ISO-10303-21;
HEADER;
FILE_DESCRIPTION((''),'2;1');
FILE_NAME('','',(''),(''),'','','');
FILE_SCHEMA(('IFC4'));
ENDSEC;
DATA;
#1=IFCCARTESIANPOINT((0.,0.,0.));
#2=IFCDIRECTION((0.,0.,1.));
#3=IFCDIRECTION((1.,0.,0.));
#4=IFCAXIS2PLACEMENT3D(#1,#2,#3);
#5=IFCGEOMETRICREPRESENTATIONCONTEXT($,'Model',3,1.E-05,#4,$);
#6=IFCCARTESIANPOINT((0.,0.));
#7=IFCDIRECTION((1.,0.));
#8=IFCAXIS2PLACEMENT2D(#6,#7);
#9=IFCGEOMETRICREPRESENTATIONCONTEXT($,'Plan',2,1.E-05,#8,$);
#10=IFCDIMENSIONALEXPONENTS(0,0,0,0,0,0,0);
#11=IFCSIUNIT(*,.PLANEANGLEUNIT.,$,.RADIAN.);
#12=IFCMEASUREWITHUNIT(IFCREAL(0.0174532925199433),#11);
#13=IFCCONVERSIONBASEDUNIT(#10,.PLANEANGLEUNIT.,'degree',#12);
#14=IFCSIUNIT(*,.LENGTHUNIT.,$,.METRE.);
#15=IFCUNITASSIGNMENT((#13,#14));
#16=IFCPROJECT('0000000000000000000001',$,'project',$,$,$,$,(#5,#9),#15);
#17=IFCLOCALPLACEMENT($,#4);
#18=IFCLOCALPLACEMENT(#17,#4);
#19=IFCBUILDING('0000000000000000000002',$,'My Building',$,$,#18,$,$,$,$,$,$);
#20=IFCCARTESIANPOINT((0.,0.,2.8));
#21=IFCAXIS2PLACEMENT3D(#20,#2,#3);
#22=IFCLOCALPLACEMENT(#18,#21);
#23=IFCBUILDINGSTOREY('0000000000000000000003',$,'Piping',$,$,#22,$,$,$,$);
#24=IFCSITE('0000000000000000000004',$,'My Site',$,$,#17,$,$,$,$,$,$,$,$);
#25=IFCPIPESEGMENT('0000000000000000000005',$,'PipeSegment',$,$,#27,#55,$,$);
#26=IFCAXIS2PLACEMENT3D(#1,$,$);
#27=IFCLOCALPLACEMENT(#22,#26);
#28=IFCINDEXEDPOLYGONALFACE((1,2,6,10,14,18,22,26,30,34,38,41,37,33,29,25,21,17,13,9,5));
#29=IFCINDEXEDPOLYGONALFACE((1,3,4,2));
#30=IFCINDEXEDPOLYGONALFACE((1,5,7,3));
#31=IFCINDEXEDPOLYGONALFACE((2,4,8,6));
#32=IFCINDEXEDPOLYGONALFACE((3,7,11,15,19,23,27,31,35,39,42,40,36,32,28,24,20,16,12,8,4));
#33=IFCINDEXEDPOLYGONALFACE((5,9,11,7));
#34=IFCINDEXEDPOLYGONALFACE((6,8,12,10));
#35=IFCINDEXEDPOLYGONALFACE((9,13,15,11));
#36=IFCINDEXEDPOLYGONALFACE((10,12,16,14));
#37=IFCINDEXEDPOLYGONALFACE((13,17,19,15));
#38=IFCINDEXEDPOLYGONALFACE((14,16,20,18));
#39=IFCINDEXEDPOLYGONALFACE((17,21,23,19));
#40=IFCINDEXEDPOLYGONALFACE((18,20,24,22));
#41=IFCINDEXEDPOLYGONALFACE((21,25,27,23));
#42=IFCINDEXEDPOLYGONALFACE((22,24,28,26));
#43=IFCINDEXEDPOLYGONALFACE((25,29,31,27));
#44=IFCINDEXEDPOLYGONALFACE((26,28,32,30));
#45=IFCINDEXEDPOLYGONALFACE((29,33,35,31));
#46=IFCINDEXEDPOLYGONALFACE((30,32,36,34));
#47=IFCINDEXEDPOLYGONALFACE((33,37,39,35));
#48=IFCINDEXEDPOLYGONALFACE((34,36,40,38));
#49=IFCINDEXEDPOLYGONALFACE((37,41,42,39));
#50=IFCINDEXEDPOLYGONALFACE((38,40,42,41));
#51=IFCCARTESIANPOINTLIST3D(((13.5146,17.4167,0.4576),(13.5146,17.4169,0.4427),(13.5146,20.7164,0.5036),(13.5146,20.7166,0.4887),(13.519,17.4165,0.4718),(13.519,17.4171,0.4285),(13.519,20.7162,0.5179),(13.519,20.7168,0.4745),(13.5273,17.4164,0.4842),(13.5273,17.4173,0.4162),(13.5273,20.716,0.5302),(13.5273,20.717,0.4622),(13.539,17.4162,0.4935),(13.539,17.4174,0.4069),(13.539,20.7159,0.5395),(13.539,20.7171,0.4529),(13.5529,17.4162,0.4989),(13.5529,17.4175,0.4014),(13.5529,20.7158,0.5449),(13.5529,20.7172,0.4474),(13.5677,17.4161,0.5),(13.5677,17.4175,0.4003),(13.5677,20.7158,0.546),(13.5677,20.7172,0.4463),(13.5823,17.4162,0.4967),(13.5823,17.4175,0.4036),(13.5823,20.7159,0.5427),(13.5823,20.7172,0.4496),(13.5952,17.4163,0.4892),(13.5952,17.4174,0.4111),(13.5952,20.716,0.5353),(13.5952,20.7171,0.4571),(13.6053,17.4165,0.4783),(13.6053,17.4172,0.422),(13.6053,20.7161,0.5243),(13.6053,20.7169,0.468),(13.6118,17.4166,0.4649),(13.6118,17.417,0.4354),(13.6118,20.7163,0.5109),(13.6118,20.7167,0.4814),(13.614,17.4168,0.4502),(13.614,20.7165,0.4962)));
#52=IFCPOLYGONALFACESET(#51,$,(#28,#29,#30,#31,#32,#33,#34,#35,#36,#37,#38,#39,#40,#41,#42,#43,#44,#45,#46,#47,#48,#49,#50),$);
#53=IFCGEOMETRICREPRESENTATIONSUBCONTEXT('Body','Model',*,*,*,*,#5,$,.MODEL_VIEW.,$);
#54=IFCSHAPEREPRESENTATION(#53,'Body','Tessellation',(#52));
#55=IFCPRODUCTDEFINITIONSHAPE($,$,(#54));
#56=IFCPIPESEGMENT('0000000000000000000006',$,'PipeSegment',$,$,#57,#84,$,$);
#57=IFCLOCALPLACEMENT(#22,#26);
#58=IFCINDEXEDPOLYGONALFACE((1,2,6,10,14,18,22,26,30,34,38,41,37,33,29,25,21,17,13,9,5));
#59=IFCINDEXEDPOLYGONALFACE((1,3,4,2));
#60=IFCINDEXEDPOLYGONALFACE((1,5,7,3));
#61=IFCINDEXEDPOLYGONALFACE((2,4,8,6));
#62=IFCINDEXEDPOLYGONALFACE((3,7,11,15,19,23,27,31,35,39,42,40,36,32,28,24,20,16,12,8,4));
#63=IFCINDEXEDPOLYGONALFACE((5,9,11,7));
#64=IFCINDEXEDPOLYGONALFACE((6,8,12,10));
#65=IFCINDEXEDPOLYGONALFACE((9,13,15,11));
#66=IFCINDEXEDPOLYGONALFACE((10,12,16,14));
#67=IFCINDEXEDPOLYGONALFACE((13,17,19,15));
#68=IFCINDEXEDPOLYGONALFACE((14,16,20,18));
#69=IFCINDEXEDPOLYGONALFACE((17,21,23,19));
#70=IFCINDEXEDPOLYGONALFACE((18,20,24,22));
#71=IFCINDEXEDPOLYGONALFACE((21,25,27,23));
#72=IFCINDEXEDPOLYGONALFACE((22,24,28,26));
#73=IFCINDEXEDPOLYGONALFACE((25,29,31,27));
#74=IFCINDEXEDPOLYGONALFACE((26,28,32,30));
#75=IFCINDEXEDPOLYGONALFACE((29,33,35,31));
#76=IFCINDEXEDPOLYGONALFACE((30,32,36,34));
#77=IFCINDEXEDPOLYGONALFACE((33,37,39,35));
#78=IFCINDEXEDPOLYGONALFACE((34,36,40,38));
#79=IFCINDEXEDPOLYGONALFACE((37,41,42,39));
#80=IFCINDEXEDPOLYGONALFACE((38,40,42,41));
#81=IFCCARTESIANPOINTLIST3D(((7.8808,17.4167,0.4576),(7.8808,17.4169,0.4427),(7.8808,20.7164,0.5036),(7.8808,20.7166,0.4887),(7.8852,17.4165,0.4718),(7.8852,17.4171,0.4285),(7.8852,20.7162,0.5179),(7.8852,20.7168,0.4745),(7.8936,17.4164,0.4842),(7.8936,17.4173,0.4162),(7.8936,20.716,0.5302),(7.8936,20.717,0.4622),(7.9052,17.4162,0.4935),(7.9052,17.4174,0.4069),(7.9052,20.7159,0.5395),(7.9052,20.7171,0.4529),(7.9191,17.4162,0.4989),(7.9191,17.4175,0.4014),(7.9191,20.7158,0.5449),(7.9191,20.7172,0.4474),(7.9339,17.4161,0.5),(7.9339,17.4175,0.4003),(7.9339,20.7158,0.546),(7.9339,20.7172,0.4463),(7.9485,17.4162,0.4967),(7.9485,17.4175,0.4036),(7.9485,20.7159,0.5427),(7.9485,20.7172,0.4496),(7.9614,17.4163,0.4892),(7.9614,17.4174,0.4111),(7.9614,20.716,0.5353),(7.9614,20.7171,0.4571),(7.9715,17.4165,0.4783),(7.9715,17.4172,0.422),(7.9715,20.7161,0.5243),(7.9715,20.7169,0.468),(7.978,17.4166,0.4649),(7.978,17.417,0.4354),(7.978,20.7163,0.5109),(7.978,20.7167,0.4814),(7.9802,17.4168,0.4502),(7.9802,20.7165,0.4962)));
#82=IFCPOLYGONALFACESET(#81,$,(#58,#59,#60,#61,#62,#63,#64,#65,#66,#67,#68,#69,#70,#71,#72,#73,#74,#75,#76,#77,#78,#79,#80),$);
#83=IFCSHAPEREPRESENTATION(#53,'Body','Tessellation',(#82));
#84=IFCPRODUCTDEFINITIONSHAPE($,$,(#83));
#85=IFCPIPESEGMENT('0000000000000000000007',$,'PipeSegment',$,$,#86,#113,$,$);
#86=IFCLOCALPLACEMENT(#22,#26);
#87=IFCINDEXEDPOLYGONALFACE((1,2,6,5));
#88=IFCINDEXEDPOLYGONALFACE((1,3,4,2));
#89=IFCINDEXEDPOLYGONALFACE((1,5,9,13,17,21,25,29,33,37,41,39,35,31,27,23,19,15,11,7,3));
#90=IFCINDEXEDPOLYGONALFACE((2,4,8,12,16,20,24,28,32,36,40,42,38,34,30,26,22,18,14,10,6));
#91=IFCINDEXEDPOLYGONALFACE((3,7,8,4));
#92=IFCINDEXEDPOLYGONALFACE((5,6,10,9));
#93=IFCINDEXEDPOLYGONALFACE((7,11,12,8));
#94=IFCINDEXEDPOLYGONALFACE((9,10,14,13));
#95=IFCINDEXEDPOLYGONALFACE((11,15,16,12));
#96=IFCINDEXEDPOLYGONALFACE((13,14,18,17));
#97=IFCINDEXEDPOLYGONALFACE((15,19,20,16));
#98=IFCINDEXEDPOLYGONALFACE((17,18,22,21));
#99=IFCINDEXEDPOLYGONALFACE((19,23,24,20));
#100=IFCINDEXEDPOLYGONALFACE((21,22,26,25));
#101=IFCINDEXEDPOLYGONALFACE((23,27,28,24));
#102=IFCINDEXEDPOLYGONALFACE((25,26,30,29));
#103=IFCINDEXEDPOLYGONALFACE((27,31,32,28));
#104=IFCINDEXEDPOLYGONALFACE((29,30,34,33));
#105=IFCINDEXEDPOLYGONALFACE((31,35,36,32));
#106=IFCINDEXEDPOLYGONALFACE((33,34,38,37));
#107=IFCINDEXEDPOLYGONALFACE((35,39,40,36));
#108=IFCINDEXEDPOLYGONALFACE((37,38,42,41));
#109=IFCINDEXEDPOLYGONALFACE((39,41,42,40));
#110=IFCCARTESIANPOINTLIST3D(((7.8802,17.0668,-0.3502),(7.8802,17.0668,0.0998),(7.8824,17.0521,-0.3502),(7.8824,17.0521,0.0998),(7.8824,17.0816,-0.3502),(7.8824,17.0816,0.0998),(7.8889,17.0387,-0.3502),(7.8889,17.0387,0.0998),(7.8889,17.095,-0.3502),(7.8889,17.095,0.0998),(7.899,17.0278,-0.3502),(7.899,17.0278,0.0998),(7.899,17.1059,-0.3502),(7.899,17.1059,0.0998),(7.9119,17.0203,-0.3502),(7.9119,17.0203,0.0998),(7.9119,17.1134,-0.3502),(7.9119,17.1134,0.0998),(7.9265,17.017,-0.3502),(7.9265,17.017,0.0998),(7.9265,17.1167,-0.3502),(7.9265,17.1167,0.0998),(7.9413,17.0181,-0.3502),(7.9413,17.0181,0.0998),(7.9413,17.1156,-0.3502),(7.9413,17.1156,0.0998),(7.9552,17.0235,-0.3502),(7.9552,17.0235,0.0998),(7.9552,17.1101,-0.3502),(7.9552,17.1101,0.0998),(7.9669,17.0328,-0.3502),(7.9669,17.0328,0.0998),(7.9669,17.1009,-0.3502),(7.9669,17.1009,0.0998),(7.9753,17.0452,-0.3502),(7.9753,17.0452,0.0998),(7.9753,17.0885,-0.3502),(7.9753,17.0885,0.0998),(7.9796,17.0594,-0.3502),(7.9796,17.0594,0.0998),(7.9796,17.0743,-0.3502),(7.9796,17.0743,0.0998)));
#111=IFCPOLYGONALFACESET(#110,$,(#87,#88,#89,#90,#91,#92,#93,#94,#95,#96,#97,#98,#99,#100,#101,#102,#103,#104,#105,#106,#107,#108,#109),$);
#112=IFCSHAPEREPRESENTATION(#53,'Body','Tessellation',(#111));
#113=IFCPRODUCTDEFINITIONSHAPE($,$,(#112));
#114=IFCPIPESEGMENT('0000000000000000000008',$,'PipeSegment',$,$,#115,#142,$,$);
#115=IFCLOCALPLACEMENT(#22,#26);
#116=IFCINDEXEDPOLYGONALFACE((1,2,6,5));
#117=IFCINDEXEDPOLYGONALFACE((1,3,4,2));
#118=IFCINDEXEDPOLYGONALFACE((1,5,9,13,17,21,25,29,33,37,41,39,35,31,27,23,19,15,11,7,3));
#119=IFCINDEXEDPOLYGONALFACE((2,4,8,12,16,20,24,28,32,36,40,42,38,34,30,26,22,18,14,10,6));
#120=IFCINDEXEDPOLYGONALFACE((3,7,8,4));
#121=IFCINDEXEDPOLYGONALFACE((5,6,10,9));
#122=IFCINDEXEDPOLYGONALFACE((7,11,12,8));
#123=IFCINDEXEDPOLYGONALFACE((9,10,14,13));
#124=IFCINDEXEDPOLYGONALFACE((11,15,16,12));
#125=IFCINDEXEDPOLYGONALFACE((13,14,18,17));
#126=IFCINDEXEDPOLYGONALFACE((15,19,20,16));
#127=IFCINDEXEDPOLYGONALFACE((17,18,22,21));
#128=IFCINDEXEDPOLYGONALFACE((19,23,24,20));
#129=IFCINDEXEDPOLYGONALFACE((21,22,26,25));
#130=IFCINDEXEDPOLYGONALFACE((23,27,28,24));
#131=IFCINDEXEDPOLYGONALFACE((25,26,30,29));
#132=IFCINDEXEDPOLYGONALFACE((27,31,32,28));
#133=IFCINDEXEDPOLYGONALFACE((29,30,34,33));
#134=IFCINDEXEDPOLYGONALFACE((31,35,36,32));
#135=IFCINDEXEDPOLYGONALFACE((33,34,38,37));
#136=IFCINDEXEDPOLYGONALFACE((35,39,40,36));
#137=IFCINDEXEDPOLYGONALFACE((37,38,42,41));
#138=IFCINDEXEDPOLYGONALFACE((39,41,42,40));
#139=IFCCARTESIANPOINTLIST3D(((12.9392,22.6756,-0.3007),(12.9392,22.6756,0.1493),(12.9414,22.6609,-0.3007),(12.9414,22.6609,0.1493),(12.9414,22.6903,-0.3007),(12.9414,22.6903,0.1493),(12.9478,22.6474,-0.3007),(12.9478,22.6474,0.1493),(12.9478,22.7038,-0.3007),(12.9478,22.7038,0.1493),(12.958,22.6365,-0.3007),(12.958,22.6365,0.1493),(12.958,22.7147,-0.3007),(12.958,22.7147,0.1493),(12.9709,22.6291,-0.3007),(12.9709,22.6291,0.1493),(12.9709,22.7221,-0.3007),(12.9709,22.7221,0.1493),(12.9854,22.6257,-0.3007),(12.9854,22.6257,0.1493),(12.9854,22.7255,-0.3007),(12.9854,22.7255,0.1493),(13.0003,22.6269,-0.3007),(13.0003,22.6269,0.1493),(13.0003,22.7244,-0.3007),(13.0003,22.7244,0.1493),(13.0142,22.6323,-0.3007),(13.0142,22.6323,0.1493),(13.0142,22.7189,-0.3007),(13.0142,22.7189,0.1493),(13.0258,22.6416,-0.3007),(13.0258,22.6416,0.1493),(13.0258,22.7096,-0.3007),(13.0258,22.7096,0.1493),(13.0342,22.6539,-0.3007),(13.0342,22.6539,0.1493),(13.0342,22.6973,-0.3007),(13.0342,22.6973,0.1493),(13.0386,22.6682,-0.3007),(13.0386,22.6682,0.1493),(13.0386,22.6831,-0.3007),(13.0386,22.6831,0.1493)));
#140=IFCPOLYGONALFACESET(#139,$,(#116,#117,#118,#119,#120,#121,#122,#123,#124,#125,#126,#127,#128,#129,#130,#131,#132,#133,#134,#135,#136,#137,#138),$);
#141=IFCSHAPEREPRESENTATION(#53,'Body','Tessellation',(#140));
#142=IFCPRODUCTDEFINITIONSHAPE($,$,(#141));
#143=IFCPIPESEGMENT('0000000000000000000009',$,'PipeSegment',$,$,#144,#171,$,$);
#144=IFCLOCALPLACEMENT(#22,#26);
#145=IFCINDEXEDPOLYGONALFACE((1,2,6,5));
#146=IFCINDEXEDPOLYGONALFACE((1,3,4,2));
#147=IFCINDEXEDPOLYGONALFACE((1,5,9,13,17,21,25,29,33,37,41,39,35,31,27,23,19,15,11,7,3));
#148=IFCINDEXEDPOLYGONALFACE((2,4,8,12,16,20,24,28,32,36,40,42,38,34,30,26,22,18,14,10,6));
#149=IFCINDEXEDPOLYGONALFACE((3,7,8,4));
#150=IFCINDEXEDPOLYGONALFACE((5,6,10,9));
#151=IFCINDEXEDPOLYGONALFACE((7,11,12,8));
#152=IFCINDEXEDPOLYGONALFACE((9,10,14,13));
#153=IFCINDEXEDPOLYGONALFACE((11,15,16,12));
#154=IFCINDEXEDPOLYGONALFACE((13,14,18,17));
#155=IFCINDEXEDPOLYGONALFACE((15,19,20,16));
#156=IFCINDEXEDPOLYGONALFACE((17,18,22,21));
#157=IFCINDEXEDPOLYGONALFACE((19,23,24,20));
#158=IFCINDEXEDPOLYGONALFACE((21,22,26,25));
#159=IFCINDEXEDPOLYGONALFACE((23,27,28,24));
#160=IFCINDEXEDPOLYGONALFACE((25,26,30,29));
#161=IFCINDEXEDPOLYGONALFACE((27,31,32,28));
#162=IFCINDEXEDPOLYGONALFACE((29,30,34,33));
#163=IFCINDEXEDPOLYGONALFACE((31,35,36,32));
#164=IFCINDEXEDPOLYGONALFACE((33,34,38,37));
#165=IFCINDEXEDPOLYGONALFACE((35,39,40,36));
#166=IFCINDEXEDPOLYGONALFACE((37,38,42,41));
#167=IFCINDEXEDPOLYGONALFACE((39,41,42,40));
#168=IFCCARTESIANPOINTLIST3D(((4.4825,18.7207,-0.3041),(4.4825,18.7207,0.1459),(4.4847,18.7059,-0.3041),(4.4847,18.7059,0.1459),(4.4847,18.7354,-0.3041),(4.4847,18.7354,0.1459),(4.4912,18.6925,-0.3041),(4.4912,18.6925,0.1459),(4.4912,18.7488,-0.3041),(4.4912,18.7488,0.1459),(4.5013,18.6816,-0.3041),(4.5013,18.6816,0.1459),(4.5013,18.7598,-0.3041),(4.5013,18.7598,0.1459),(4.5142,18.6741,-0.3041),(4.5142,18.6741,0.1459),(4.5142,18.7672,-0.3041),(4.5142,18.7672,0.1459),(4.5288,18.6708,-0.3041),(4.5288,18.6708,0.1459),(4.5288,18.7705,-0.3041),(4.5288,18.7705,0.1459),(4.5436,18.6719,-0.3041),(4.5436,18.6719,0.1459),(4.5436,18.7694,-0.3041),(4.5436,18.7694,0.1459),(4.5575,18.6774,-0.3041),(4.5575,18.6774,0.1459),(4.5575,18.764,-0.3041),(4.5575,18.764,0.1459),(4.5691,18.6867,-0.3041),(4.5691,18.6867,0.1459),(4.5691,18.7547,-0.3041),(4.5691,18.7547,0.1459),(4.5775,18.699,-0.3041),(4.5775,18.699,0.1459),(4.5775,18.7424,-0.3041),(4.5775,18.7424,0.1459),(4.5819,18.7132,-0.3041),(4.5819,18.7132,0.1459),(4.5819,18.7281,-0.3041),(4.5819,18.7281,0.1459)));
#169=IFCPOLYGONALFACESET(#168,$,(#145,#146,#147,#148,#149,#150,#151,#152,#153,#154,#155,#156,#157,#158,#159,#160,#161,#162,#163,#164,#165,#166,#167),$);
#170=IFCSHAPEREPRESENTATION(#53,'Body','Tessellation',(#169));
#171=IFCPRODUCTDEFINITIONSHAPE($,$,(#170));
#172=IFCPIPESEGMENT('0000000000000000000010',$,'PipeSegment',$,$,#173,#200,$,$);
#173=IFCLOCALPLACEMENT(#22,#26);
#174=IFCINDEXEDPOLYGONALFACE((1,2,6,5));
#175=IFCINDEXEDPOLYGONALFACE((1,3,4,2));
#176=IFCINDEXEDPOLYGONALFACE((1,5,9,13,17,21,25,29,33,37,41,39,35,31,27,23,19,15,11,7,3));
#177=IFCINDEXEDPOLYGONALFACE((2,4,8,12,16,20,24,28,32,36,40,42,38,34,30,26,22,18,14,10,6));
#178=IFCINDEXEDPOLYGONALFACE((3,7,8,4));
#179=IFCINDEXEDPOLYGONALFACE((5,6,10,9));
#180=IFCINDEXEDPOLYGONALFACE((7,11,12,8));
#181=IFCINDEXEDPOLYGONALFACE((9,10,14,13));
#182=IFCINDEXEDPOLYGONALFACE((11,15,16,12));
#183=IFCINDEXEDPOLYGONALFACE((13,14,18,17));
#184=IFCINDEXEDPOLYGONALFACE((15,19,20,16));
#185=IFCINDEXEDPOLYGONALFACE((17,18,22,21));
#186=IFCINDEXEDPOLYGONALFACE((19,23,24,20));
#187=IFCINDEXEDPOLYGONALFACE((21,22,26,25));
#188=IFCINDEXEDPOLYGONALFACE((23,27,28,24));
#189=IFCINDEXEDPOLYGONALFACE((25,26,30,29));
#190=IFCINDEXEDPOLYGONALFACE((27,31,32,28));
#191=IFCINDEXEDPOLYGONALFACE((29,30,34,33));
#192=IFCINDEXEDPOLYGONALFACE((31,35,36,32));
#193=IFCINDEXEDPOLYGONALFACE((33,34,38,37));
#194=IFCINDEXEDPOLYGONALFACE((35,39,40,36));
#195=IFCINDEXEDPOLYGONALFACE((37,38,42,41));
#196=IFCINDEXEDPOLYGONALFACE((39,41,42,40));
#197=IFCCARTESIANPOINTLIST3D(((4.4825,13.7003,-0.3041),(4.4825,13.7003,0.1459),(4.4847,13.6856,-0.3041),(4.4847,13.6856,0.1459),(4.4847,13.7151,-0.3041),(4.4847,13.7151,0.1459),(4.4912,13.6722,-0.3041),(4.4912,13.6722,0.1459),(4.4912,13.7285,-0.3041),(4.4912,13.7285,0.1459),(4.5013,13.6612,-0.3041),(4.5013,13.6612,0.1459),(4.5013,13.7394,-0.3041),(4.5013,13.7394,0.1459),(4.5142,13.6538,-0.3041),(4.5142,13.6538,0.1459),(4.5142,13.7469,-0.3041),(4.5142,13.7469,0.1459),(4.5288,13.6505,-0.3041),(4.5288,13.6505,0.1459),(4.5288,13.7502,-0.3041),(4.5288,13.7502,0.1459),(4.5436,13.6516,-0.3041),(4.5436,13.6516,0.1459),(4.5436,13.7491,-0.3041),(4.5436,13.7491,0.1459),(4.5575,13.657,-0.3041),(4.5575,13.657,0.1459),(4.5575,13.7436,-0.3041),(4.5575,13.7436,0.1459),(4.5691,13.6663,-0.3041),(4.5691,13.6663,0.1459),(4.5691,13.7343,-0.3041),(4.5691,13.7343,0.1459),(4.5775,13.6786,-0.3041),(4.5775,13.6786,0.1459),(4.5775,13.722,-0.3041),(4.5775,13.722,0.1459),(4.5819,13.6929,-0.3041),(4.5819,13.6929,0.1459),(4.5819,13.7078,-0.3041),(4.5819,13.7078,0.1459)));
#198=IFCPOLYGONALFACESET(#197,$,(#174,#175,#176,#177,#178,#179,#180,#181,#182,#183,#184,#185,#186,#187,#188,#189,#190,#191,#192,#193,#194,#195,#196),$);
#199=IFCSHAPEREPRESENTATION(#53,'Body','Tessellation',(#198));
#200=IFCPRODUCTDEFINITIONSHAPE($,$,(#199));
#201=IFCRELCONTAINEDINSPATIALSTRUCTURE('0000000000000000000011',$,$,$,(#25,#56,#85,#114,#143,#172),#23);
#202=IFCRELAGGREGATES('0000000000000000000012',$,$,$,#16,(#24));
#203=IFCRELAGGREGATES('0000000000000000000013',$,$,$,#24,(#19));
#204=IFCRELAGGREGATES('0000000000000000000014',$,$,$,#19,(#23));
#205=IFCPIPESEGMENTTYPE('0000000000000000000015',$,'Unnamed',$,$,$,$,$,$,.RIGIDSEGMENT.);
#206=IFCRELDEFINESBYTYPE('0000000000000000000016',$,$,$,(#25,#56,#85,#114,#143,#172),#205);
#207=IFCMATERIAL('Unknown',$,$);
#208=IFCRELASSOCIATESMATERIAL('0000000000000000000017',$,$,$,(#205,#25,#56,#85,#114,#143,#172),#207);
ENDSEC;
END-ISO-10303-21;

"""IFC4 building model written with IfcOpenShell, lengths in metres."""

from ifc_helpers import new_model, entity, si_unit, converted_unit, frame, origin_with_axes, origin_2d_with_axis, place, context, subcontext, project, spatial, circle, extrude, material, material_profile, profile_set, profile_usage, type_object, element, save


model = new_model("IFC4")

# Units and contexts
model_context = context("Model", 3, precision=1e-05, world=origin_with_axes())
plan_context = context("Plan", 2, precision=1e-05, world=origin_2d_with_axis())
body_context = subcontext(model_context, "Body", "Model", "MODEL_VIEW")
ifc_project = project(units=[converted_unit("PLANEANGLEUNIT", "degree", entity("IfcReal", 0.0174532925199433), si_unit("PLANEANGLEUNIT", "RADIAN"), dimensions=[0, 0, 0, 0, 0, 0, 0]), si_unit("LENGTHUNIT", "METRE")], contexts=[model_context, plan_context])

# Site, building, storey
site_placement = place(None, origin_with_axes())
site = spatial("IfcSite", under=ifc_project, at=site_placement, Name="My Site")
building_placement = place(site_placement, origin_with_axes())
building = spatial("IfcBuilding", under=site, at=building_placement, Name="My Building")
storey_placement = place(building_placement, frame((0.0, 0.0, 2.8), z_axis=(0.0, 0.0, 1.0), x_axis=(1.0, 0.0, 0.0)))
storey = spatial("IfcBuildingStorey", under=building, at=storey_placement, Name="Piping")

# Pipe segments
ifc_material = material(Name="Unknown")
ifc_material_profile_1 = material_profile(ifc_material, circle(Radius=0.05))
ifc_profile_set_1 = profile_set([ifc_material_profile_1])
pipe_segment_type = type_object("IfcPipeSegmentType", Name="Unnamed", PredefinedType="RIGIDSEGMENT", material=ifc_profile_set_1)
ifc_profile_usage_1 = profile_usage(ifc_profile_set_1, cardinal=5)
pipe_segment_1_placement = place(storey_placement, frame((13.564, 20.7165, 0.4962), z_axis=(0.0, -0.999903, -0.013947), x_axis=(1.0, 0.0, 0.0)))
element("IfcPipeSegment", 1, at=pipe_segment_1_placement, inside=storey, type_object=pipe_segment_type, material=ifc_profile_usage_1, Name="PipeSegment", context=body_context, shape_type="SweptSolid", body=[
    extrude(circle(Radius=0.05), origin_with_axes(), (0.0, 0.0, 1.0), 3.3),
])
ifc_profile_usage_2 = profile_usage(ifc_profile_set_1, cardinal=5)
pipe_segment_2_placement = place(storey_placement, frame((7.9302, 20.7165, 0.4962), z_axis=(0.0, -0.999903, -0.013947), x_axis=(1.0, 0.0, 0.0)))
element("IfcPipeSegment", 2, at=pipe_segment_2_placement, inside=storey, type_object=pipe_segment_type, material=ifc_profile_usage_2, Name="PipeSegment", context=body_context, shape_type="SweptSolid", body=[
    extrude(circle(Radius=0.05), origin_with_axes(), (0.0, 0.0, 1.0), 3.3),
])
ifc_profile_usage_3 = profile_usage(ifc_profile_set_1, cardinal=5)
pipe_segment_3_placement = place(storey_placement, frame((7.9302, 17.0668, 0.0998), z_axis=(0.0, 0.0, -1.0), x_axis=(-1.0, 0.0, 0.0)))
element("IfcPipeSegment", 3, at=pipe_segment_3_placement, inside=storey, type_object=pipe_segment_type, material=ifc_profile_usage_3, Name="PipeSegment", context=body_context, shape_type="SweptSolid", body=[
    extrude(circle(Radius=0.05), origin_with_axes(), (0.0, 0.0, 1.0), 0.45),
])
ifc_profile_usage_4 = profile_usage(ifc_profile_set_1, cardinal=5)
pipe_segment_4_placement = place(storey_placement, frame((12.9892, 22.6756, 0.1493), z_axis=(0.0, 0.0, -1.0), x_axis=(-1.0, 0.0, 0.0)))
element("IfcPipeSegment", 4, at=pipe_segment_4_placement, inside=storey, type_object=pipe_segment_type, material=ifc_profile_usage_4, Name="PipeSegment", context=body_context, shape_type="SweptSolid", body=[
    extrude(circle(Radius=0.05), origin_with_axes(), (0.0, 0.0, 1.0), 0.45),
])
ifc_profile_usage_5 = profile_usage(ifc_profile_set_1, cardinal=5)
pipe_segment_5_placement = place(storey_placement, frame((4.5325, 18.7207, 0.1459), z_axis=(0.0, 0.0, -1.0), x_axis=(-1.0, 0.0, 0.0)))
element("IfcPipeSegment", 5, at=pipe_segment_5_placement, inside=storey, type_object=pipe_segment_type, material=ifc_profile_usage_5, Name="PipeSegment", context=body_context, shape_type="SweptSolid", body=[
    extrude(circle(Radius=0.05), origin_with_axes(), (0.0, 0.0, 1.0), 0.45),
])
ifc_profile_usage_6 = profile_usage(ifc_profile_set_1, cardinal=5)
pipe_segment_6_placement = place(storey_placement, frame((4.5325, 13.7003, 0.1459), z_axis=(0.0, 0.0, -1.0), x_axis=(-1.0, 0.0, 0.0)))
element("IfcPipeSegment", 6, at=pipe_segment_6_placement, inside=storey, type_object=pipe_segment_type, material=ifc_profile_usage_6, Name="PipeSegment", context=body_context, shape_type="SweptSolid", body=[
    extrude(circle(Radius=0.05), origin_with_axes(), (0.0, 0.0, 1.0), 0.45),
])

save(model, "model.ifc")
